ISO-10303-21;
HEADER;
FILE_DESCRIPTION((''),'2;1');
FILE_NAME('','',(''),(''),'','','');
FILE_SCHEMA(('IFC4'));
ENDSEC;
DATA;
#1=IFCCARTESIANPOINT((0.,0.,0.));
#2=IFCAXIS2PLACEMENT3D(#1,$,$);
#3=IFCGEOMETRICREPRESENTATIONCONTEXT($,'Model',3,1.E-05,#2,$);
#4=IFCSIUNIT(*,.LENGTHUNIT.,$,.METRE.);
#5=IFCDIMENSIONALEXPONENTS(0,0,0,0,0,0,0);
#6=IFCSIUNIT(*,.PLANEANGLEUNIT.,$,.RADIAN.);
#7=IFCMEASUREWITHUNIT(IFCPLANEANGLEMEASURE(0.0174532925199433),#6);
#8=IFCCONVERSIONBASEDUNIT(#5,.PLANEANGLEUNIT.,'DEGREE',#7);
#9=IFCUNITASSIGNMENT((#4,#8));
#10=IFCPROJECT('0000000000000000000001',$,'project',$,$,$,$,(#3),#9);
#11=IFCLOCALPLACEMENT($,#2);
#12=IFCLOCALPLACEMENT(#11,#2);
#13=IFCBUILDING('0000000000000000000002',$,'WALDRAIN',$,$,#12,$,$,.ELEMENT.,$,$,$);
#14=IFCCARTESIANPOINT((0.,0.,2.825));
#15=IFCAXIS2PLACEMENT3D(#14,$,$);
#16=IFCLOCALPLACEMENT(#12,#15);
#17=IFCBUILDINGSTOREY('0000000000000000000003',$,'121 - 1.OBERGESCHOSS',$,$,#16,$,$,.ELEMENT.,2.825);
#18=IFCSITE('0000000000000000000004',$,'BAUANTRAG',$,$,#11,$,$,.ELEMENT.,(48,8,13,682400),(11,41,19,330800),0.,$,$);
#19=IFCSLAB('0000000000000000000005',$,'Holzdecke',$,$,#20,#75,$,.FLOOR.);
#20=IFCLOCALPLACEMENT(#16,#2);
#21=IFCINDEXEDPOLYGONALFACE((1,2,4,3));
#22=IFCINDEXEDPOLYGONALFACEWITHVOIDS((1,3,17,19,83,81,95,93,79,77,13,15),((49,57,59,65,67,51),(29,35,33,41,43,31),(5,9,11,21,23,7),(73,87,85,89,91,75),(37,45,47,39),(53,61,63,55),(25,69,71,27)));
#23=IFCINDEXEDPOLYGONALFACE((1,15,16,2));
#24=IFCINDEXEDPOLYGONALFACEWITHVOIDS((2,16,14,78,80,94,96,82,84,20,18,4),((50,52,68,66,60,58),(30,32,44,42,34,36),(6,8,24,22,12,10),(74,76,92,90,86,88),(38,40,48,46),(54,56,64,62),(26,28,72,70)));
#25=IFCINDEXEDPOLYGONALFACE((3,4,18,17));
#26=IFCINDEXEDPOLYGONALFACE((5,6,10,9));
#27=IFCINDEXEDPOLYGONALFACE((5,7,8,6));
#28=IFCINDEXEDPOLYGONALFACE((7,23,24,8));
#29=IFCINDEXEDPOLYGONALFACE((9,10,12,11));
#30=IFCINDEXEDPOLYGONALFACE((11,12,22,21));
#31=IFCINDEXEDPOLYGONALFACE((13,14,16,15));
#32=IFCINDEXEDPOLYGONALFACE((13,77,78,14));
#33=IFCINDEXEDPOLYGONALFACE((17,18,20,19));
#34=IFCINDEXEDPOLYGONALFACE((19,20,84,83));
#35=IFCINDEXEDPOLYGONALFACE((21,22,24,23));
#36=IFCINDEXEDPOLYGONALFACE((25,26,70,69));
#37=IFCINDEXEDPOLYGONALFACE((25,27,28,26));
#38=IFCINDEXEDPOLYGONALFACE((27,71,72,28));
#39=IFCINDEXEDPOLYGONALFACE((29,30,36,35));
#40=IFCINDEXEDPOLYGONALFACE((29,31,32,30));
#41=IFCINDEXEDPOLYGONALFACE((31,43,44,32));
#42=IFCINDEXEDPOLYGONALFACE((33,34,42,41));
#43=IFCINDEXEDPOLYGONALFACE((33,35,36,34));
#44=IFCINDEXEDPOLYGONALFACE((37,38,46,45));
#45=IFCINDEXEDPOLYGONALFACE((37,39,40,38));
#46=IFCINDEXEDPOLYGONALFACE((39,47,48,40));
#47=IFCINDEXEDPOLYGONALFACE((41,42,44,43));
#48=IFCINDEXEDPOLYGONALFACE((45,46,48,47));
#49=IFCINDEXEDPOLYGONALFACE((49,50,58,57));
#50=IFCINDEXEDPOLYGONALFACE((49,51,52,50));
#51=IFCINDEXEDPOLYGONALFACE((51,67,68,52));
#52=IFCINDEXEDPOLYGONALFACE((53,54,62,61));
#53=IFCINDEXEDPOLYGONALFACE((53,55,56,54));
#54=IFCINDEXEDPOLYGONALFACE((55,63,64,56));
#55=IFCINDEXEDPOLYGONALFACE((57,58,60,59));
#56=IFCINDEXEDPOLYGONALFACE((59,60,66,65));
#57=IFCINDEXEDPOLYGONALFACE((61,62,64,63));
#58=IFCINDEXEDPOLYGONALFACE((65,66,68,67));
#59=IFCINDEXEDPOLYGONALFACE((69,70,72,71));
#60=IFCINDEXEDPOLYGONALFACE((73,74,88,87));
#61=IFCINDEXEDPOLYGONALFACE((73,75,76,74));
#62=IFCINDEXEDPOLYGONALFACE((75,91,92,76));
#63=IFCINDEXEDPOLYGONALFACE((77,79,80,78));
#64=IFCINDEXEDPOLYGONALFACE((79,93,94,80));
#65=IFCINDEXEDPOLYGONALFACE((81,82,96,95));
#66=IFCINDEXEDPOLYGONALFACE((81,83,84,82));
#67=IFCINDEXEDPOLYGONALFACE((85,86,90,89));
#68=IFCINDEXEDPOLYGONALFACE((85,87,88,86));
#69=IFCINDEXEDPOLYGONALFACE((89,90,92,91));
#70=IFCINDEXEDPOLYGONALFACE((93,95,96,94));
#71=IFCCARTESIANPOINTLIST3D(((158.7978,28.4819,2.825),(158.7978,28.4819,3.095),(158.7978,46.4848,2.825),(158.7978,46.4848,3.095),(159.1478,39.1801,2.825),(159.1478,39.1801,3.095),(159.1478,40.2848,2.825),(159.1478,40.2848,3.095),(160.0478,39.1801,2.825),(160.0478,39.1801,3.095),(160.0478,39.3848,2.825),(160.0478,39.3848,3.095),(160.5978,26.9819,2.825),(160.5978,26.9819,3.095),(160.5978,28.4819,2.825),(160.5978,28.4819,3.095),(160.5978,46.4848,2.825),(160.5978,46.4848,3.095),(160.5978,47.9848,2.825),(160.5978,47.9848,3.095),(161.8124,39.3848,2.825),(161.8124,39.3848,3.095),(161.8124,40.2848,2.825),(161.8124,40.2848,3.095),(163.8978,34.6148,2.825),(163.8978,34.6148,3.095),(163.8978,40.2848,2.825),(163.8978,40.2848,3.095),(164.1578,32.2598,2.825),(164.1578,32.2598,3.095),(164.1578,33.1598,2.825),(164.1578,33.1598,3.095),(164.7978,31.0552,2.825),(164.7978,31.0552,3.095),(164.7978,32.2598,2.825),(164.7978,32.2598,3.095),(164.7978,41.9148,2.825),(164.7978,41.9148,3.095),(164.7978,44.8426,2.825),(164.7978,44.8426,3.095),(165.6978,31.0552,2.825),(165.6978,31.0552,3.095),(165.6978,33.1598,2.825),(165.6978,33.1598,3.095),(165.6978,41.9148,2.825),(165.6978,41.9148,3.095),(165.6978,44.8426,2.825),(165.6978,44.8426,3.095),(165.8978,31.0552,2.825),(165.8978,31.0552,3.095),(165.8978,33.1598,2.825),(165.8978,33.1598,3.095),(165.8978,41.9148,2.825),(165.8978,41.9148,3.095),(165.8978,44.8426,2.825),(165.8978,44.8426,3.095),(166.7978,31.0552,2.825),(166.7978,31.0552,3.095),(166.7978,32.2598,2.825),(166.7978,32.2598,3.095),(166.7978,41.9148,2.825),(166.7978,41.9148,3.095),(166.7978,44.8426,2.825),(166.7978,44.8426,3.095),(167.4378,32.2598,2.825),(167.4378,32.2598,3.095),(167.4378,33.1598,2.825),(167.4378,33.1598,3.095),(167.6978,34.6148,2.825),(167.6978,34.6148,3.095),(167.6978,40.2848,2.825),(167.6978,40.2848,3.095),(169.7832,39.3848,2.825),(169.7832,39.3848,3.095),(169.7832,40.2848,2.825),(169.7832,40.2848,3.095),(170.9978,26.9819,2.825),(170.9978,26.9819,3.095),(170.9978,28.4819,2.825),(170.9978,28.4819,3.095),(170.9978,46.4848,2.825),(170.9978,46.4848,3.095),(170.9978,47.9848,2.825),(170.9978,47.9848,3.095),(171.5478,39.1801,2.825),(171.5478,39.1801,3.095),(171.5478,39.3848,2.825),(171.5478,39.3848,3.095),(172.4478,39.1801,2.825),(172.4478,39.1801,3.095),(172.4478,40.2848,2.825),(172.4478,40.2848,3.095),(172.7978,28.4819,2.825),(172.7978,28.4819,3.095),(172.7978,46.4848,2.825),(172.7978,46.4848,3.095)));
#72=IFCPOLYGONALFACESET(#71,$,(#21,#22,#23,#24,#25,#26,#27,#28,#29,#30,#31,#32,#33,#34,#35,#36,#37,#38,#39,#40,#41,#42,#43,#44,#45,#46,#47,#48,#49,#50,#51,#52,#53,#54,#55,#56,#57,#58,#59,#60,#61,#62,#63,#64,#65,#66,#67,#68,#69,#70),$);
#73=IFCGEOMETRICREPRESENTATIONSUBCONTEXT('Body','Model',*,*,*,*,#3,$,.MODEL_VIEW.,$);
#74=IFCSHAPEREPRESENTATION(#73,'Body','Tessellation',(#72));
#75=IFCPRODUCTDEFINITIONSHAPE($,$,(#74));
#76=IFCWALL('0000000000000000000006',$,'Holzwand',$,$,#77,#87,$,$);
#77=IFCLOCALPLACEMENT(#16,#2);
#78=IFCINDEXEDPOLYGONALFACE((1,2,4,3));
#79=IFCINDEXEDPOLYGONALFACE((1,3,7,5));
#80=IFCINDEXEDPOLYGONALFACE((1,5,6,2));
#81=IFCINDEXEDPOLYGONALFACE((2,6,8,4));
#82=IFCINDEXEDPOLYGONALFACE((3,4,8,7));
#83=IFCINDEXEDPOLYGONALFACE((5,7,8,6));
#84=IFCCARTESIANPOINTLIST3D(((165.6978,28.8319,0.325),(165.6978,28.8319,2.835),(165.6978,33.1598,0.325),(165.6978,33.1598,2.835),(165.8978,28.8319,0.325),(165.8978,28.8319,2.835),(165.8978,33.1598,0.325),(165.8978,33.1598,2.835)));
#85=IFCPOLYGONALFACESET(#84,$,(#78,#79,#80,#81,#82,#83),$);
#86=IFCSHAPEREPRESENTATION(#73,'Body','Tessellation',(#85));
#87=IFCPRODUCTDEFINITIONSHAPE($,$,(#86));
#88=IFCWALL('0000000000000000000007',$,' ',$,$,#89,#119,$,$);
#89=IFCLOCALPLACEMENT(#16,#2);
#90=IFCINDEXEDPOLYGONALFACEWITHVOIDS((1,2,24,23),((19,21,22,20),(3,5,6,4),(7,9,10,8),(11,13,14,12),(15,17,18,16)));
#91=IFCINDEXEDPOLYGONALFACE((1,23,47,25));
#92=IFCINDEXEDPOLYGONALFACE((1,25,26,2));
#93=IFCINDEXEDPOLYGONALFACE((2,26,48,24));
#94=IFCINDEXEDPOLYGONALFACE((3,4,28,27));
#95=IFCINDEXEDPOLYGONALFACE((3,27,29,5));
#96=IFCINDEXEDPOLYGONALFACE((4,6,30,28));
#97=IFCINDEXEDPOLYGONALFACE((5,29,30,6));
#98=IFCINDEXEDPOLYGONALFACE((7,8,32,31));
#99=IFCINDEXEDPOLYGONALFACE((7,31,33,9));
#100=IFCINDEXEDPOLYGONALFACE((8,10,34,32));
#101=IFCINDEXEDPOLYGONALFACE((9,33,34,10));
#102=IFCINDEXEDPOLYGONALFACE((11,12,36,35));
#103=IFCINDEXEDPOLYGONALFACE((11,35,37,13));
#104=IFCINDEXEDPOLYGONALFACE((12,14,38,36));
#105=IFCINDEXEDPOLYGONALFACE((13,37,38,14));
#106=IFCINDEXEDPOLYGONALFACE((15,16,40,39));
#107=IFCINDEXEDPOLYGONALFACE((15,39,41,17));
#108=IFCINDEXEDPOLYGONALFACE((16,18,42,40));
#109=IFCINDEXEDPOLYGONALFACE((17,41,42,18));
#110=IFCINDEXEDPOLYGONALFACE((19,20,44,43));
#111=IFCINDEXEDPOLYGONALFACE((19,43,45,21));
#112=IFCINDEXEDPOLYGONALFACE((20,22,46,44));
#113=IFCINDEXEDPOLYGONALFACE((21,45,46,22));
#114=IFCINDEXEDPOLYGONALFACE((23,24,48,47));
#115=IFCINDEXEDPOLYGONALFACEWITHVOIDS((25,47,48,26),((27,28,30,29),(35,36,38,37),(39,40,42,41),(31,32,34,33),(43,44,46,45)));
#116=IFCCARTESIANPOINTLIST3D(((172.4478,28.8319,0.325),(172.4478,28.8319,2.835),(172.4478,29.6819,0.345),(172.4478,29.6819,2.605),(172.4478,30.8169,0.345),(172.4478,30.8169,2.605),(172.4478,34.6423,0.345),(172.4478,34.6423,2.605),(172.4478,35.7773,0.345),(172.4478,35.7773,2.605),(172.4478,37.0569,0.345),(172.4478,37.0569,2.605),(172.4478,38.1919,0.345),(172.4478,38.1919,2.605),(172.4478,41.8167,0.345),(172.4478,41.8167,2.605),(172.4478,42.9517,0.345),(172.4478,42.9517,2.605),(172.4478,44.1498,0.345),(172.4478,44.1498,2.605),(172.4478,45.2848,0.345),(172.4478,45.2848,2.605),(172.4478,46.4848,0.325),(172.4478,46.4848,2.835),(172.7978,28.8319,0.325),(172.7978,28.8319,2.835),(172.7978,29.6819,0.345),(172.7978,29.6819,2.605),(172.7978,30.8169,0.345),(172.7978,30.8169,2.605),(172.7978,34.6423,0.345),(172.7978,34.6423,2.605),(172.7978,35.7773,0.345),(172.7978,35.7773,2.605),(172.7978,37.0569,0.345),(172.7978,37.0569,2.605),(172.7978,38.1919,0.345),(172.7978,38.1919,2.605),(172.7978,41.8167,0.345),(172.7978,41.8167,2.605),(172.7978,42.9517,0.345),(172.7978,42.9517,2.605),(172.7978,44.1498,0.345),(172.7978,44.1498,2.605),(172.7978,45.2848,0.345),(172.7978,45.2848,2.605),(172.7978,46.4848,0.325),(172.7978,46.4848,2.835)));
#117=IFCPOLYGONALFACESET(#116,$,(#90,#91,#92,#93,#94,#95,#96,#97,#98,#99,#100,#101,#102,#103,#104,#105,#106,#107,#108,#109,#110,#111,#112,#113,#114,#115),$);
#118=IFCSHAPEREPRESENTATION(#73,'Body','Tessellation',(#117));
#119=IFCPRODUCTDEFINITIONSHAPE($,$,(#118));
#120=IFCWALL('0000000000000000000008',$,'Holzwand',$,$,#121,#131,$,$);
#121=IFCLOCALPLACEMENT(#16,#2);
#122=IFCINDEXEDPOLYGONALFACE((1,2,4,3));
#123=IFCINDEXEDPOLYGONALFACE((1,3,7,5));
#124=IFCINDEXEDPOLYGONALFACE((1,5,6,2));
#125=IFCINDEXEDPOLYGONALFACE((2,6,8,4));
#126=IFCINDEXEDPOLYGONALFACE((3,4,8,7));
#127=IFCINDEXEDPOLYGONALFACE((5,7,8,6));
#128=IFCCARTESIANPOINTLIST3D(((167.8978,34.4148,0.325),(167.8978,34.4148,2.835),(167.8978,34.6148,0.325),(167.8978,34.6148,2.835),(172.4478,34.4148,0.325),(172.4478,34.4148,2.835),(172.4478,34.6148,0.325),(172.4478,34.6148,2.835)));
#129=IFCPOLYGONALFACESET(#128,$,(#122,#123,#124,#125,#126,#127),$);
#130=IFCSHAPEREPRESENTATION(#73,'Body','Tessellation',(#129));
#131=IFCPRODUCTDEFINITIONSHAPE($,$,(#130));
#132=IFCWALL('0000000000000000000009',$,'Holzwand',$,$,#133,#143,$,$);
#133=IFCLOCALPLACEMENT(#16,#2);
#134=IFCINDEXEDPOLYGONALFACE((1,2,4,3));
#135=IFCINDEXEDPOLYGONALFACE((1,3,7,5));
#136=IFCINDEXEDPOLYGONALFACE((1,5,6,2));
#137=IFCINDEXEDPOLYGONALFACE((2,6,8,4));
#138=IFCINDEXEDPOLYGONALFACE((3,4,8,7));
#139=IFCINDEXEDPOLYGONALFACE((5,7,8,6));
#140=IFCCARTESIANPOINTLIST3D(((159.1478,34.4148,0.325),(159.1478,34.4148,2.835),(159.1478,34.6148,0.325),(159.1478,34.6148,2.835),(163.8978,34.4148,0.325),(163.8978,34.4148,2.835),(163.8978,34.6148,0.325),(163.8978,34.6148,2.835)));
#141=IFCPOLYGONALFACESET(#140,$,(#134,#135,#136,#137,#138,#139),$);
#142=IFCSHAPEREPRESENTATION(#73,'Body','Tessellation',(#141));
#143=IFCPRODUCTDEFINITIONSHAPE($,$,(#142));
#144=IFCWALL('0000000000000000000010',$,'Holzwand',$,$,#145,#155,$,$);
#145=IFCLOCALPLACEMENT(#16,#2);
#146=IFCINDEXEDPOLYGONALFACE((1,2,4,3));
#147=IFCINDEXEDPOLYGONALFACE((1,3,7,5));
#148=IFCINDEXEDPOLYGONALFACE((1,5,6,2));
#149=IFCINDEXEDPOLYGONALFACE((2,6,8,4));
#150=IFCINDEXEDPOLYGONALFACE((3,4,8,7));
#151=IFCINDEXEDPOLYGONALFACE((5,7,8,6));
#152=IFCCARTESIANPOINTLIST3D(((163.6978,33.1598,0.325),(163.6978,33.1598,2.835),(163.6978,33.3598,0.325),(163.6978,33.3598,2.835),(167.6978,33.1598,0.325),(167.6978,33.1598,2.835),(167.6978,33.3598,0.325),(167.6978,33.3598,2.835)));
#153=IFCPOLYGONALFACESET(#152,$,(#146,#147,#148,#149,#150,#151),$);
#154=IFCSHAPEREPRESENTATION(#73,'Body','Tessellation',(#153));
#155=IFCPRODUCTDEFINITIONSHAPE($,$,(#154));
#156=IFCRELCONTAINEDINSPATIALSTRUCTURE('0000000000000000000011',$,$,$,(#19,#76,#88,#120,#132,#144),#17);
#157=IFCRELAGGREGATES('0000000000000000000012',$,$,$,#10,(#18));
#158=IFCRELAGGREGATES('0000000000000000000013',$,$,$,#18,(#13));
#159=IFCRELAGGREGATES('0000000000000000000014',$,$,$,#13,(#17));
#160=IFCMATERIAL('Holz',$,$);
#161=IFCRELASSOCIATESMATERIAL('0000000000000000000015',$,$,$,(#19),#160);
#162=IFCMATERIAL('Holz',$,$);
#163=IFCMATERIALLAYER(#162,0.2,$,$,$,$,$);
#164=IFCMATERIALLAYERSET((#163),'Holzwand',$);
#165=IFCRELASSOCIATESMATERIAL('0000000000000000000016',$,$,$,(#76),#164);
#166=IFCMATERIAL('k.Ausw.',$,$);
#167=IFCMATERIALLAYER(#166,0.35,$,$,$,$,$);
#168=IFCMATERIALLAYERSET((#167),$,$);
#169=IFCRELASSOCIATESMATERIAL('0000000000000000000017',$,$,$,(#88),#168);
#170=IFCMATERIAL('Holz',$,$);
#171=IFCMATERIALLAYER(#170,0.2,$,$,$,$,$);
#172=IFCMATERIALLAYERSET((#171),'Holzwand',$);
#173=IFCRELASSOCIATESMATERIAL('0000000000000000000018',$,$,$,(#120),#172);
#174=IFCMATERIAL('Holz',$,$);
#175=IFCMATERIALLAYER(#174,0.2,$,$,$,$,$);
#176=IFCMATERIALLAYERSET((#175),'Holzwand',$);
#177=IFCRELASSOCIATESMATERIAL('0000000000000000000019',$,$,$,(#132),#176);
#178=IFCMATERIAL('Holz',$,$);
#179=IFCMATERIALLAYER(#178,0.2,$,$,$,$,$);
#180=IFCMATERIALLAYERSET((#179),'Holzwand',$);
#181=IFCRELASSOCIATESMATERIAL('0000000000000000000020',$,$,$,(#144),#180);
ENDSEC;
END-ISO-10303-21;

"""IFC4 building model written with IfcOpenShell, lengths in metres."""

from ifc_helpers import new_model, entity, si_unit, converted_unit, frame, frame_2d, origin, origin_with_axes, place, context, subcontext, project, spatial, polyline, rectangle, outline, extrude, material, layer, layer_set, layer_usage, element, save


model = new_model("IFC4")

# Units and contexts
model_context = context("Model", 3, precision=1e-05, world=origin())
body_context = subcontext(model_context, "Body", "Model", "MODEL_VIEW")
ifc_project = project(units=[si_unit("LENGTHUNIT", "METRE"), converted_unit("PLANEANGLEUNIT", "DEGREE", entity("IfcPlaneAngleMeasure", 0.0174532925199433), si_unit("PLANEANGLEUNIT", "RADIAN"), dimensions=[0, 0, 0, 0, 0, 0, 0])], contexts=[model_context])

# Site, building, storey
site_placement = place(None, origin())
site = spatial("IfcSite", under=ifc_project, at=site_placement, Name="BAUANTRAG", CompositionType="ELEMENT", RefLatitude=(48, 8, 13, 682400), RefLongitude=(11, 41, 19, 330800), RefElevation=0.0)
building_placement = place(site_placement, origin())
building = spatial("IfcBuilding", under=site, at=building_placement, Name="WALDRAIN", CompositionType="ELEMENT")
storey_placement = place(building_placement, frame((0.0, 0.0, 2.825)))
storey = spatial("IfcBuildingStorey", under=building, at=storey_placement, Name="121 - 1.OBERGESCHOSS", CompositionType="ELEMENT", Elevation=2.825)

# Slab, opening
ifc_material_1 = material(Name="Holz")
slab_placement = place(storey_placement, frame((158.7978, 26.9819, 2.825)))
slab = element("IfcSlab", 1, at=slab_placement, inside=storey, material=ifc_material_1, Name="Holzdecke", PredefinedType="FLOOR", context=body_context, shape_type="SweptSolid", body=[
    extrude(outline(polyline([(0.0, 1.5), (1.8, 1.5), (1.8, 0.0), (12.2, 0.0), (12.2, 1.5), (14.0, 1.5), (14.0, 19.5029), (12.2, 19.5029), (12.2, 21.0029), (1.8, 21.0029), (1.8, 19.5029), (0.0, 19.5029), (0.0, 1.5)]), holes=[polyline([(5.1, 7.6329), (5.1, 13.3029), (8.9, 13.3029), (8.9, 7.6329), (5.1, 7.6329)]), polyline([(6.9, 14.9329), (6.0, 14.9329), (6.0, 17.8607), (6.9, 17.8607), (6.9, 14.9329)]), polyline([(7.1, 17.8607), (8.0, 17.8607), (8.0, 14.9329), (7.1, 14.9329), (7.1, 17.8607)]), polyline([(12.75, 12.1981), (12.75, 12.4029), (10.9854, 12.4029), (10.9854, 13.3029), (13.65, 13.3029), (13.65, 12.1981), (12.75, 12.1981)]), polyline([(6.0, 5.2779), (5.36, 5.2779), (5.36, 6.1779), (6.9, 6.1779), (6.9, 4.0733), (6.0, 4.0733), (6.0, 5.2779)]), polyline([(7.1, 4.0733), (7.1, 6.1779), (8.64, 6.1779), (8.64, 5.2779), (8.0, 5.2779), (8.0, 4.0733), (7.1, 4.0733)])]), origin_with_axes(), (0.0, 0.0, 1.0), 0.27),
])
opening_1_placement = place(slab_placement, frame((0.35, 12.1981, 0.0)))
element("IfcOpeningElement", 2, at=opening_1_placement, cuts=slab, ObjectType="Opening", context=body_context, shape_type="SweptSolid", body=[
    extrude(outline(polyline([(1.4764, 0.6682), (-1.1882, 0.6682), (-1.1882, -0.4365), (-0.2882, -0.4365), (-0.2882, -0.2318), (1.4764, -0.2318), (1.4764, 0.6682)])), frame((1.1882, 0.4365, 0.0), z_axis=(0.0, 0.0, 1.0), x_axis=(1.0, 0.0, 0.0)), (0.0, 0.0, 1.0), 0.27),
])

# Wall
ifc_material_2 = material(Name="Holz")
ifc_layer_1 = layer(ifc_material_2, 0.2)
ifc_layer_set_1 = layer_set([ifc_layer_1], Name="Holzwand")
ifc_layer_usage_1 = layer_usage(ifc_layer_set_1, "AXIS2", "POSITIVE", 0.0)
wall_1_placement = place(storey_placement, frame((165.6978, 33.1598, 0.325), z_axis=(0.0, 0.0, 1.0), x_axis=(0.0, -1.0, 0.0)))
element("IfcWall", 3, at=wall_1_placement, inside=storey, material=ifc_layer_usage_1, Name="Holzwand", context=body_context, shape_type="SweptSolid", body=[
    extrude(rectangle(XDim=4.3279, YDim=0.2, at=frame_2d((2.1639, 0.1), x_axis=(1.0, 0.0))), origin_with_axes(), (0.0, 0.0, 1.0), 2.51),
])

# Wall, openings
ifc_material_3 = material(Name="k.Ausw.")
ifc_layer_2 = layer(ifc_material_3, 0.35)
ifc_layer_set_2 = layer_set([ifc_layer_2])
ifc_layer_usage_2 = layer_usage(ifc_layer_set_2, "AXIS2", "POSITIVE", 0.0)
wall_2_placement = place(storey_placement, frame((172.7978, 28.8319, 0.325), z_axis=(0.0, 0.0, 1.0), x_axis=(0.0, 1.0, 0.0)))
wall_2 = element("IfcWall", 4, at=wall_2_placement, inside=storey, material=ifc_layer_usage_2, Name=" ", context=body_context, shape_type="SweptSolid", body=[
    extrude(rectangle(XDim=17.6529, YDim=0.35, at=frame_2d((8.8264, 0.175), x_axis=(1.0, 0.0))), origin_with_axes(), (0.0, 0.0, 1.0), 2.51),
])
opening_2_placement = place(wall_2_placement, frame((1.985, 0.35, 0.02), z_axis=(0.0, -1.0, 0.0), x_axis=(0.0, 0.0, 1.0)))
element("IfcOpeningElement", 5, at=opening_2_placement, cuts=wall_2, ObjectType="Opening", context=body_context, shape_type="SweptSolid", body=[
    extrude(outline(polyline([(0.0, 1.135), (2.26, 1.135), (2.26, 0.0), (0.0, 0.0), (0.0, 1.135)])), origin_with_axes(), (0.0, 0.0, 1.0), 0.35),
])
opening_3_placement = place(wall_2_placement, frame((9.36, 0.35, 0.02), z_axis=(0.0, -1.0, 0.0), x_axis=(0.0, 0.0, 1.0)))
element("IfcOpeningElement", 6, at=opening_3_placement, cuts=wall_2, ObjectType="Opening", context=body_context, shape_type="SweptSolid", body=[
    extrude(outline(polyline([(0.0, 1.135), (2.26, 1.135), (2.26, 0.0), (0.0, 0.0), (0.0, 1.135)])), origin_with_axes(), (0.0, 0.0, 1.0), 0.35),
])
opening_4_placement = place(wall_2_placement, frame((6.9454, 0.35, 0.02), z_axis=(0.0, -1.0, 0.0), x_axis=(0.0, 0.0, 1.0)))
element("IfcOpeningElement", 7, at=opening_4_placement, cuts=wall_2, ObjectType="Opening", context=body_context, shape_type="SweptSolid", body=[
    extrude(outline(polyline([(0.0, 1.135), (2.26, 1.135), (2.26, 0.0), (0.0, 0.0), (0.0, 1.135)])), origin_with_axes(), (0.0, 0.0, 1.0), 0.35),
])
opening_5_placement = place(wall_2_placement, frame((16.4529, 0.35, 0.02), z_axis=(0.0, -1.0, 0.0), x_axis=(0.0, 0.0, 1.0)))
element("IfcOpeningElement", 8, at=opening_5_placement, cuts=wall_2, ObjectType="Opening", context=body_context, shape_type="SweptSolid", body=[
    extrude(outline(polyline([(0.0, 1.135), (2.26, 1.135), (2.26, 0.0), (0.0, 0.0), (0.0, 1.135)])), origin_with_axes(), (0.0, 0.0, 1.0), 0.35),
])
opening_6_placement = place(wall_2_placement, frame((14.1198, 0.35, 0.02), z_axis=(0.0, -1.0, 0.0), x_axis=(0.0, 0.0, 1.0)))
element("IfcOpeningElement", 9, at=opening_6_placement, cuts=wall_2, ObjectType="Opening", context=body_context, shape_type="SweptSolid", body=[
    extrude(outline(polyline([(0.0, 1.135), (2.26, 1.135), (2.26, 0.0), (0.0, 0.0), (0.0, 1.135)])), origin_with_axes(), (0.0, 0.0, 1.0), 0.35),
])

# Walls
ifc_material_4 = material(Name="Holz")
ifc_layer_3 = layer(ifc_material_4, 0.2)
ifc_layer_set_3 = layer_set([ifc_layer_3], Name="Holzwand")
ifc_layer_usage_3 = layer_usage(ifc_layer_set_3, "AXIS2", "POSITIVE", 0.0)
wall_3_placement = place(storey_placement, frame((167.8978, 34.4148, 0.325)))
element("IfcWall", 10, at=wall_3_placement, inside=storey, material=ifc_layer_usage_3, Name="Holzwand", context=body_context, shape_type="SweptSolid", body=[
    extrude(rectangle(XDim=4.55, YDim=0.2, at=frame_2d((2.275, 0.1), x_axis=(1.0, 0.0))), origin_with_axes(), (0.0, 0.0, 1.0), 2.51),
])
ifc_material_5 = material(Name="Holz")
ifc_layer_4 = layer(ifc_material_5, 0.2)
ifc_layer_set_4 = layer_set([ifc_layer_4], Name="Holzwand")
ifc_layer_usage_4 = layer_usage(ifc_layer_set_4, "AXIS2", "POSITIVE", 0.0)
wall_4_placement = place(storey_placement, frame((159.1478, 34.4148, 0.325)))
element("IfcWall", 11, at=wall_4_placement, inside=storey, material=ifc_layer_usage_4, Name="Holzwand", context=body_context, shape_type="SweptSolid", body=[
    extrude(rectangle(XDim=4.75, YDim=0.2, at=frame_2d((2.375, 0.1), x_axis=(1.0, 0.0))), origin_with_axes(), (0.0, 0.0, 1.0), 2.51),
])
ifc_material_6 = material(Name="Holz")
ifc_layer_5 = layer(ifc_material_6, 0.2)
ifc_layer_set_5 = layer_set([ifc_layer_5], Name="Holzwand")
ifc_layer_usage_5 = layer_usage(ifc_layer_set_5, "AXIS2", "POSITIVE", 0.0)
wall_5_placement = place(storey_placement, frame((167.6978, 33.3598, 0.325), z_axis=(0.0, 0.0, 1.0), x_axis=(-1.0, 0.0, 0.0)))
element("IfcWall", 12, at=wall_5_placement, inside=storey, material=ifc_layer_usage_5, Name="Holzwand", context=body_context, shape_type="SweptSolid", body=[
    extrude(rectangle(XDim=4.0, YDim=0.2, at=frame_2d((2.0, 0.1), x_axis=(1.0, 0.0))), origin_with_axes(), (0.0, 0.0, 1.0), 2.51),
])

save(model, "model.ifc")
